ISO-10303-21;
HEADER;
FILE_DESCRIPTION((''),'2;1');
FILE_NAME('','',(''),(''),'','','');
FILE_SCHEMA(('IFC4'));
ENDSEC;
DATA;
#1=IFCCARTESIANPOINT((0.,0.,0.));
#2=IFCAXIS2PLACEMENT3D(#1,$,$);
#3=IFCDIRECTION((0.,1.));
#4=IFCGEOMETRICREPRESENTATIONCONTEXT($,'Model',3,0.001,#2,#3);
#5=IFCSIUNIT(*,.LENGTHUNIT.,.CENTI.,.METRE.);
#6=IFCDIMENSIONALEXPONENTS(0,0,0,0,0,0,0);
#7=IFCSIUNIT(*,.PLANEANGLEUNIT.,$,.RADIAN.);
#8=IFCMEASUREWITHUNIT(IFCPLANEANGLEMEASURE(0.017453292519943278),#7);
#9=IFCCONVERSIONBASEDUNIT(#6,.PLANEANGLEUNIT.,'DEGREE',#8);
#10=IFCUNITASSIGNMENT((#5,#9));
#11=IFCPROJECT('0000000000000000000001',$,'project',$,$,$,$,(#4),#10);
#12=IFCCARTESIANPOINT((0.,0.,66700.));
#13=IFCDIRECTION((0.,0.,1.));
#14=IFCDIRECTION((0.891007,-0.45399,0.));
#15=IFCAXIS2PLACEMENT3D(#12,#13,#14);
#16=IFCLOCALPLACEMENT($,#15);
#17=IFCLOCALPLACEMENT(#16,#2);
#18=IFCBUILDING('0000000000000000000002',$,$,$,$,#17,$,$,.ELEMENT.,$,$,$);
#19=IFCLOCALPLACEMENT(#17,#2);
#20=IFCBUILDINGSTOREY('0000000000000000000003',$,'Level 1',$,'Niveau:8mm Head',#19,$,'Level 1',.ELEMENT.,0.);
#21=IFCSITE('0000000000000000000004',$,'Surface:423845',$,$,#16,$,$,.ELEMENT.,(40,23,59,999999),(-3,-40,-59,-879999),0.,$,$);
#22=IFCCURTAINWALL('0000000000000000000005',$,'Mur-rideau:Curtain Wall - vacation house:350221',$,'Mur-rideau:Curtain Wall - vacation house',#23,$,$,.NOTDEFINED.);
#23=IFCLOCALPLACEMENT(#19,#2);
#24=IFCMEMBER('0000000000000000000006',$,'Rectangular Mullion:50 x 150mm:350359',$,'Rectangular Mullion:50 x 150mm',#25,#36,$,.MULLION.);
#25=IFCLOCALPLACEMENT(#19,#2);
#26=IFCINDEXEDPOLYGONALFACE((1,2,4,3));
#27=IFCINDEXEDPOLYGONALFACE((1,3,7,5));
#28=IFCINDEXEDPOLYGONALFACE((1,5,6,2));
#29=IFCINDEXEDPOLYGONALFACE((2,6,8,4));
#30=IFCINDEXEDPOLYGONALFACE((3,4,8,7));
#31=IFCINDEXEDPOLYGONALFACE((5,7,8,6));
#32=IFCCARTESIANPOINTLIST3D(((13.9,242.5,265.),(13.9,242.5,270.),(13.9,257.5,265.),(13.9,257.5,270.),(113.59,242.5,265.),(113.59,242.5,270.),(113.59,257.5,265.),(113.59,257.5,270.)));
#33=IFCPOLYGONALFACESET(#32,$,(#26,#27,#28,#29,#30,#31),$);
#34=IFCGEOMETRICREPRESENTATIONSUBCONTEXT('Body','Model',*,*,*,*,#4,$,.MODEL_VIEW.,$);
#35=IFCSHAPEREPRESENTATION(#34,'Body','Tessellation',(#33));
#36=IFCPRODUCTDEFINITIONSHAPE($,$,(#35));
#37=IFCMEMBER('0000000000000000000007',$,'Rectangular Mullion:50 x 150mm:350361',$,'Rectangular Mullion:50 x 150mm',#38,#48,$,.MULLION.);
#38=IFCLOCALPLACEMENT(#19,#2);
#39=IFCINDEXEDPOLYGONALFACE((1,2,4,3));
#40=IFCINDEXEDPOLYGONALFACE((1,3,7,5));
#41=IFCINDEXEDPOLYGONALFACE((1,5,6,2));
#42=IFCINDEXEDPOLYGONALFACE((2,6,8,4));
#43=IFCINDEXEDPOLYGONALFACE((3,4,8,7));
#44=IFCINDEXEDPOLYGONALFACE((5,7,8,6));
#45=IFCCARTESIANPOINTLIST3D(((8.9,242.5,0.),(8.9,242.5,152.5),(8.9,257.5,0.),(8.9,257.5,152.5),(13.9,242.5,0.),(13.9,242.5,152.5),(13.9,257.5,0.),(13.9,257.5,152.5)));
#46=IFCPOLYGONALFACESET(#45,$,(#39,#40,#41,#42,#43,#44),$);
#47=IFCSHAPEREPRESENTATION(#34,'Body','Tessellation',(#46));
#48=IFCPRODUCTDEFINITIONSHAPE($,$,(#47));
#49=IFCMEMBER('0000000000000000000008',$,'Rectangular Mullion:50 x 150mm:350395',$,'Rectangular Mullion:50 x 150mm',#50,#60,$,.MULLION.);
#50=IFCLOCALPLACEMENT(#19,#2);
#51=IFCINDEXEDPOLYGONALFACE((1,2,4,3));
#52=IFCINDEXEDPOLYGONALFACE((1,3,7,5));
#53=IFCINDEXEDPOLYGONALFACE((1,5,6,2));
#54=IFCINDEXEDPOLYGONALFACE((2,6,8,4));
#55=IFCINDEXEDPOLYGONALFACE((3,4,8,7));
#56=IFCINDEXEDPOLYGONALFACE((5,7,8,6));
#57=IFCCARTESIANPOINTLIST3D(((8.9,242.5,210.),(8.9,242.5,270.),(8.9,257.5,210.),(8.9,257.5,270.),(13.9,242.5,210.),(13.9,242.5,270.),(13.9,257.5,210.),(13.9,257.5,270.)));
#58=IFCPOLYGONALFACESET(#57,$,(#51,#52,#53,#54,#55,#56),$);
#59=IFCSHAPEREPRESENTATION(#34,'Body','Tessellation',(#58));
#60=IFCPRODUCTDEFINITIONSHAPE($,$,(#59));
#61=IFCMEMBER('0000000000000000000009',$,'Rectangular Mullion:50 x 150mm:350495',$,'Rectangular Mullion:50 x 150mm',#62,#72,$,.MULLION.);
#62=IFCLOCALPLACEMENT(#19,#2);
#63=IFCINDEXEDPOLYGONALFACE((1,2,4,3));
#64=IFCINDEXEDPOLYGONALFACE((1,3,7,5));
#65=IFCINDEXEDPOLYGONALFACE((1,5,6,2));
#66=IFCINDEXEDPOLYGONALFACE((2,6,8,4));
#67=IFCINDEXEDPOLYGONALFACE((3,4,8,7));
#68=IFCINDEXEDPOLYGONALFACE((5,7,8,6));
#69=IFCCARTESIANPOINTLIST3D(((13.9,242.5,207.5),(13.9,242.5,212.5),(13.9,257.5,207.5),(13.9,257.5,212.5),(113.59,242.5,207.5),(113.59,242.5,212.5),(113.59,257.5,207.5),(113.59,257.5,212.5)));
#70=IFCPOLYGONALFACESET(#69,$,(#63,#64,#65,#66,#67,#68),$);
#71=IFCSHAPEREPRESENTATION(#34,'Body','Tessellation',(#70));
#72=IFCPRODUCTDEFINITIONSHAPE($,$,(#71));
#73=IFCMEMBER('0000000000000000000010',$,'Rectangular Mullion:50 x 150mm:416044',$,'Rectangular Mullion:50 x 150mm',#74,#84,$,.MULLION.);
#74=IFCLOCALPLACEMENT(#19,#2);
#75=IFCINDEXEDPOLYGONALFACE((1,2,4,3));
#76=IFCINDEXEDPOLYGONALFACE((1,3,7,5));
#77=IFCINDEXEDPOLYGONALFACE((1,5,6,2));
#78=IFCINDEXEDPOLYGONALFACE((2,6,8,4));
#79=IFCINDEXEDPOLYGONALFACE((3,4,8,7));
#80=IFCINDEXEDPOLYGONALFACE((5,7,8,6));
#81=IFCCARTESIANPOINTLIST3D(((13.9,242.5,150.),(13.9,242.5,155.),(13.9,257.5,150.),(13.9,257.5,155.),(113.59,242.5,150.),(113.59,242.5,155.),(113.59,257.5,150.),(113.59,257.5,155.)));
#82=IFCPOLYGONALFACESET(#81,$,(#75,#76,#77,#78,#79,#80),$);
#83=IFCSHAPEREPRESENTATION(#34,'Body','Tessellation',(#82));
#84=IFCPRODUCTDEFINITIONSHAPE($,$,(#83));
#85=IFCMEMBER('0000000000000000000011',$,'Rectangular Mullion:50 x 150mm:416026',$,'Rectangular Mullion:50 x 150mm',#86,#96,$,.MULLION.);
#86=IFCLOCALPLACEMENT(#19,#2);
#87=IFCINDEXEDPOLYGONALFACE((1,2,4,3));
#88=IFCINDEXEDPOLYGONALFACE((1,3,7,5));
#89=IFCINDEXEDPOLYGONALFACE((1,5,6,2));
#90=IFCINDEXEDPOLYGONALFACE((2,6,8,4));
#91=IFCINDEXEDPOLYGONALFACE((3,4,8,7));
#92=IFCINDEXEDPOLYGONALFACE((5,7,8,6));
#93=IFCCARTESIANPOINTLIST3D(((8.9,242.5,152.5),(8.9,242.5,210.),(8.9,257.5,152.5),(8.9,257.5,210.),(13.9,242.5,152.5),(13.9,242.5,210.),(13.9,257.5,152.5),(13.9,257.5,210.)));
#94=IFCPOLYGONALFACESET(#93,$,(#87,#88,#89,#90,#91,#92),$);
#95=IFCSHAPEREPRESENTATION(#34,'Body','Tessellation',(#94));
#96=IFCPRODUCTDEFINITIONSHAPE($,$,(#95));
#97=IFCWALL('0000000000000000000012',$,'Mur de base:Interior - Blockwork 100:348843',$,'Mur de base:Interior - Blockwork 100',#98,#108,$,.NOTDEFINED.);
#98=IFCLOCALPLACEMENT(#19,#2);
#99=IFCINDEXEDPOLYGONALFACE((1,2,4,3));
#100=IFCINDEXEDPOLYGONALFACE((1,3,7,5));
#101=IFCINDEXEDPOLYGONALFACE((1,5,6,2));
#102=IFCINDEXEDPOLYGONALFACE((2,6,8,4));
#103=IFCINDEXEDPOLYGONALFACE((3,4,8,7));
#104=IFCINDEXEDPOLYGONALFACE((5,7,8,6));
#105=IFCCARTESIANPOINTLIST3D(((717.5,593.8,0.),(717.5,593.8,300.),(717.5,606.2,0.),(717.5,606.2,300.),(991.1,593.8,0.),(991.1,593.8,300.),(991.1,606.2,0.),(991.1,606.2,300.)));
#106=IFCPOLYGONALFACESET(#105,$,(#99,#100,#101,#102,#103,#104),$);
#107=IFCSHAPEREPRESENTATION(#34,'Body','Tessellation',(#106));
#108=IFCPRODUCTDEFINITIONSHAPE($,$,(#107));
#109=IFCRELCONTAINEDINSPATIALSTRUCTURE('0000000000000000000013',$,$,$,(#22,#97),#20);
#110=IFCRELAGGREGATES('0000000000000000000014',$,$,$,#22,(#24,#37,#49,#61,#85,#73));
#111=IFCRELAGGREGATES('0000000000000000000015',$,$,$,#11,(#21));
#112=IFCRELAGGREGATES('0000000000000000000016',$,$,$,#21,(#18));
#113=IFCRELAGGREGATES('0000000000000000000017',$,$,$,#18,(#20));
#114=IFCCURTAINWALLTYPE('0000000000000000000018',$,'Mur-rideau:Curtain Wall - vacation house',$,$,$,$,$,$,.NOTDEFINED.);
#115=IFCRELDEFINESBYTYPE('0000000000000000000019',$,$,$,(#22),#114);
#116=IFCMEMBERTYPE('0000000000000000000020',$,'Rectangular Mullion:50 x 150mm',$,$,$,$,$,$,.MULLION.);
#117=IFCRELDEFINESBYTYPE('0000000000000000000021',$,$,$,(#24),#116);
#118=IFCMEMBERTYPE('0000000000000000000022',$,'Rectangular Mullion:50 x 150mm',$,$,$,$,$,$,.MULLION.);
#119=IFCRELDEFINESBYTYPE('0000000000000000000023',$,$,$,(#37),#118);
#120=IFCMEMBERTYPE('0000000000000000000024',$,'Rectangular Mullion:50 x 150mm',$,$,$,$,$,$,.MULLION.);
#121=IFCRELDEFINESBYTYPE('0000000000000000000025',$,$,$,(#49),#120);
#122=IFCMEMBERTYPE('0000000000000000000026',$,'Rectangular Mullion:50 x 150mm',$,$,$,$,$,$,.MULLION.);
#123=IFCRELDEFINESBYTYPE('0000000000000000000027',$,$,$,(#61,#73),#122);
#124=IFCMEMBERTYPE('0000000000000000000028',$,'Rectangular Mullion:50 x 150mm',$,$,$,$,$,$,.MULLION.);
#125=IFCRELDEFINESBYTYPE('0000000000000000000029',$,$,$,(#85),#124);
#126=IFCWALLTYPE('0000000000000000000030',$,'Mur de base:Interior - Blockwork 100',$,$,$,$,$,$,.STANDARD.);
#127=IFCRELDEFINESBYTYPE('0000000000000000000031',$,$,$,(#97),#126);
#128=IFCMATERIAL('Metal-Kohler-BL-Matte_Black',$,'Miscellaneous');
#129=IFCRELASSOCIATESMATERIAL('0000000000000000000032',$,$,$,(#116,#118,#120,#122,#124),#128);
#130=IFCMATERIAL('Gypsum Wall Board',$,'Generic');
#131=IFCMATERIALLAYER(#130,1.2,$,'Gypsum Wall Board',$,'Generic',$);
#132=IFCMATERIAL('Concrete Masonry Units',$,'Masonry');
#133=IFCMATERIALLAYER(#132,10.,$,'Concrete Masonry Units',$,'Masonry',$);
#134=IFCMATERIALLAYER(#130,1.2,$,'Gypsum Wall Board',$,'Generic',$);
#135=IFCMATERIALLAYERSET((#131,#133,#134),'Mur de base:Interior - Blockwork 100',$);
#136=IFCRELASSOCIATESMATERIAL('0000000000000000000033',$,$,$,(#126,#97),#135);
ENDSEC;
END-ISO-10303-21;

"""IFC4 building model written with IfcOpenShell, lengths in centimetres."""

from ifc_helpers import new_model, entity, si_unit, converted_unit, direction, frame, frame_2d, origin, origin_2d_with_axis, place, context, subcontext, project, spatial, rectangle, extrude, source, transform, mapped, material, layer, layer_set, layer_usage, material_profile, profile_set, type_object, type_shapes, element, aggregate, save


model = new_model("IFC4")

# Units and contexts
model_context = context("Model", 3, precision=0.001, world=origin(), true_north=direction((0.0, 1.0)))
body_context = subcontext(model_context, "Body", "Model", "MODEL_VIEW")
ifc_project = project(units=[si_unit("LENGTHUNIT", "METRE", prefix="CENTI"), converted_unit("PLANEANGLEUNIT", "DEGREE", entity("IfcPlaneAngleMeasure", 0.017453292519943278), si_unit("PLANEANGLEUNIT", "RADIAN"), dimensions=[0, 0, 0, 0, 0, 0, 0])], contexts=[model_context])

# Site, building, storey
site_placement = place(None, frame((0.0, 0.0, 66700.0), z_axis=(0.0, 0.0, 1.0), x_axis=(0.891007, -0.45399, 0.0)))
site = spatial("IfcSite", under=ifc_project, at=site_placement, Name="Surface:423845", CompositionType="ELEMENT", RefLatitude=(40, 23, 59, 999999), RefLongitude=(-3, -40, -59, -879999), RefElevation=0.0)
building_placement = place(site_placement, origin())
building = spatial("IfcBuilding", under=site, at=building_placement, CompositionType="ELEMENT")
storey_placement = place(building_placement, origin())
storey = spatial("IfcBuildingStorey", under=building, at=storey_placement, Name="Level 1", ObjectType="Niveau:8mm Head", LongName="Level 1", CompositionType="ELEMENT", Elevation=0.0)

# Curtain wall, members
curtain_wall_type = type_object("IfcCurtainWallType", Name="Mur-rideau:Curtain Wall - vacation house", PredefinedType="NOTDEFINED")
curtain_wall_placement = place(storey_placement, origin())
curtain_wall = element("IfcCurtainWall", 1, at=curtain_wall_placement, inside=storey, type_object=curtain_wall_type, Name="Mur-rideau:Curtain Wall - vacation house:350221", ObjectType="Mur-rideau:Curtain Wall - vacation house", PredefinedType="NOTDEFINED")
ifc_material_1 = material(Name="Metal-Kohler-BL-Matte_Black", Category="Miscellaneous")
ifc_material_profile = material_profile(ifc_material_1, rectangle(XDim=5.0, YDim=15.0, at=origin_2d_with_axis()), Name="50 x 150mm")
ifc_profile_set = profile_set([ifc_material_profile], Name="50 x 150mm")
member_type_1 = type_object("IfcMemberType", Name="Rectangular Mullion:50 x 150mm", PredefinedType="MULLION", material=ifc_profile_set)
shared_shape_1 = source(origin(), body_context, "Body", "SweptSolid", [
    extrude(rectangle(XDim=5.0, YDim=15.0, at=origin_2d_with_axis()), frame((-2.5, 0.0, -99.69), z_axis=(0.0, 0.0, 1.0), x_axis=(-1.0, 0.0, 0.0)), (0.0, 0.0, 1.0), 99.69),
])
type_shapes(member_type_1, [shared_shape_1])
member_1_placement = place(curtain_wall_placement, frame((13.9, 250.0, 270.0), z_axis=(-1.0, 0.0, 0.0), x_axis=(0.0, 0.0, 1.0)))
member_1 = element("IfcMember", 2, at=member_1_placement, type_object=member_type_1, Name="Rectangular Mullion:50 x 150mm:350359", ObjectType="Rectangular Mullion:50 x 150mm", PredefinedType="MULLION", context=body_context, shape_type="MappedRepresentation", body=[
    mapped(shared_shape_1, transform((0.0, 0.0, 0.0), scale=1.0)),
])
member_type_2 = type_object("IfcMemberType", Name="Rectangular Mullion:50 x 150mm", PredefinedType="MULLION", material=ifc_profile_set)
shared_shape_2 = source(origin(), body_context, "Body", "SweptSolid", [
    extrude(rectangle(XDim=5.0, YDim=15.0, at=origin_2d_with_axis()), frame((-2.5, 0.0, -152.5), z_axis=(0.0, 0.0, 1.0), x_axis=(-1.0, 0.0, 0.0)), (0.0, 0.0, 1.0), 152.5),
])
type_shapes(member_type_2, [shared_shape_2])
member_2_placement = place(curtain_wall_placement, frame((8.9, 250.0, 0.0), z_axis=(0.0, 0.0, -1.0), x_axis=(-1.0, 0.0, 0.0)))
member_2 = element("IfcMember", 3, at=member_2_placement, type_object=member_type_2, Name="Rectangular Mullion:50 x 150mm:350361", ObjectType="Rectangular Mullion:50 x 150mm", PredefinedType="MULLION", context=body_context, shape_type="MappedRepresentation", body=[
    mapped(shared_shape_2, transform((0.0, 0.0, 0.0), scale=1.0)),
])
member_type_3 = type_object("IfcMemberType", Name="Rectangular Mullion:50 x 150mm", PredefinedType="MULLION", material=ifc_profile_set)
shared_shape_3 = source(origin(), body_context, "Body", "SweptSolid", [
    extrude(rectangle(XDim=5.0, YDim=15.0, at=origin_2d_with_axis()), frame((-2.5, 0.0, -60.0), z_axis=(0.0, 0.0, 1.0), x_axis=(-1.0, 0.0, 0.0)), (0.0, 0.0, 1.0), 60.0),
])
type_shapes(member_type_3, [shared_shape_3])
member_3_placement = place(curtain_wall_placement, frame((8.9, 250.0, 210.0), z_axis=(0.0, 0.0, -1.0), x_axis=(-1.0, 0.0, 0.0)))
member_3 = element("IfcMember", 4, at=member_3_placement, type_object=member_type_3, Name="Rectangular Mullion:50 x 150mm:350395", ObjectType="Rectangular Mullion:50 x 150mm", PredefinedType="MULLION", context=body_context, shape_type="MappedRepresentation", body=[
    mapped(shared_shape_3, transform((0.0, 0.0, 0.0), scale=1.0)),
])
member_type_4 = type_object("IfcMemberType", Name="Rectangular Mullion:50 x 150mm", PredefinedType="MULLION", material=ifc_profile_set)
shared_shape_4 = source(origin(), body_context, "Body", "SweptSolid", [
    extrude(rectangle(XDim=5.0, YDim=15.0, at=origin_2d_with_axis()), frame((0.0, 0.0, -99.69), z_axis=(0.0, 0.0, 1.0), x_axis=(-1.0, 0.0, 0.0)), (0.0, 0.0, 1.0), 99.69),
])
type_shapes(member_type_4, [shared_shape_4])
member_4_placement = place(curtain_wall_placement, frame((13.9, 250.0, 210.0), z_axis=(-1.0, 0.0, 0.0), x_axis=(0.0, 0.0, 1.0)))
member_4 = element("IfcMember", 5, at=member_4_placement, type_object=member_type_4, Name="Rectangular Mullion:50 x 150mm:350495", ObjectType="Rectangular Mullion:50 x 150mm", PredefinedType="MULLION", context=body_context, shape_type="MappedRepresentation", body=[
    mapped(shared_shape_4, transform((0.0, 0.0, 0.0), scale=1.0)),
])
member_5_placement = place(curtain_wall_placement, frame((13.9, 250.0, 152.5), z_axis=(-1.0, 0.0, 0.0), x_axis=(0.0, 0.0, 1.0)))
member_5 = element("IfcMember", 6, at=member_5_placement, type_object=member_type_4, Name="Rectangular Mullion:50 x 150mm:416044", ObjectType="Rectangular Mullion:50 x 150mm", PredefinedType="MULLION", context=body_context, shape_type="MappedRepresentation", body=[
    mapped(shared_shape_4, transform((0.0, 0.0, 0.0), scale=1.0)),
])
member_type_5 = type_object("IfcMemberType", Name="Rectangular Mullion:50 x 150mm", PredefinedType="MULLION", material=ifc_profile_set)
shared_shape_5 = source(origin(), body_context, "Body", "SweptSolid", [
    extrude(rectangle(XDim=5.0, YDim=15.0, at=origin_2d_with_axis()), frame((-2.5, 0.0, -57.5), z_axis=(0.0, 0.0, 1.0), x_axis=(-1.0, 0.0, 0.0)), (0.0, 0.0, 1.0), 57.5),
])
type_shapes(member_type_5, [shared_shape_5])
member_6_placement = place(curtain_wall_placement, frame((8.9, 250.0, 152.5), z_axis=(0.0, 0.0, -1.0), x_axis=(-1.0, 0.0, 0.0)))
member_6 = element("IfcMember", 7, at=member_6_placement, type_object=member_type_5, Name="Rectangular Mullion:50 x 150mm:416026", ObjectType="Rectangular Mullion:50 x 150mm", PredefinedType="MULLION", context=body_context, shape_type="MappedRepresentation", body=[
    mapped(shared_shape_5, transform((0.0, 0.0, 0.0), scale=1.0)),
])
aggregate(curtain_wall, [member_1, member_2, member_3, member_4, member_6, member_5])

# Wall
ifc_material_2 = material(Name="Gypsum Wall Board", Category="Generic")
ifc_layer_1 = layer(ifc_material_2, 1.2, Name="Gypsum Wall Board", Category="Generic")
ifc_material_3 = material(Name="Concrete Masonry Units", Category="Masonry")
ifc_layer_2 = layer(ifc_material_3, 10.0, Name="Concrete Masonry Units", Category="Masonry")
ifc_layer_3 = layer(ifc_material_2, 1.2, Name="Gypsum Wall Board", Category="Generic")
ifc_layer_set = layer_set([ifc_layer_1, ifc_layer_2, ifc_layer_3], Name="Mur de base:Interior - Blockwork 100")
ifc_layer_usage = layer_usage(ifc_layer_set, "AXIS2", "NEGATIVE", 6.2)
wall_type = type_object("IfcWallType", Name="Mur de base:Interior - Blockwork 100", PredefinedType="STANDARD", material=ifc_layer_set)
wall_placement = place(storey_placement, frame((717.5, 600.0, 0.0)))
element("IfcWall", 8, at=wall_placement, inside=storey, type_object=wall_type, material=ifc_layer_usage, Name="Mur de base:Interior - Blockwork 100:348843", ObjectType="Mur de base:Interior - Blockwork 100", PredefinedType="NOTDEFINED", context=body_context, shape_type="SweptSolid", body=[
    extrude(rectangle(XDim=273.6, YDim=12.4, at=frame_2d((136.8, 0.0), x_axis=(-1.0, 0.0))), origin(), (0.0, 0.0, 1.0), 300.0),
])

save(model, "model.ifc")
